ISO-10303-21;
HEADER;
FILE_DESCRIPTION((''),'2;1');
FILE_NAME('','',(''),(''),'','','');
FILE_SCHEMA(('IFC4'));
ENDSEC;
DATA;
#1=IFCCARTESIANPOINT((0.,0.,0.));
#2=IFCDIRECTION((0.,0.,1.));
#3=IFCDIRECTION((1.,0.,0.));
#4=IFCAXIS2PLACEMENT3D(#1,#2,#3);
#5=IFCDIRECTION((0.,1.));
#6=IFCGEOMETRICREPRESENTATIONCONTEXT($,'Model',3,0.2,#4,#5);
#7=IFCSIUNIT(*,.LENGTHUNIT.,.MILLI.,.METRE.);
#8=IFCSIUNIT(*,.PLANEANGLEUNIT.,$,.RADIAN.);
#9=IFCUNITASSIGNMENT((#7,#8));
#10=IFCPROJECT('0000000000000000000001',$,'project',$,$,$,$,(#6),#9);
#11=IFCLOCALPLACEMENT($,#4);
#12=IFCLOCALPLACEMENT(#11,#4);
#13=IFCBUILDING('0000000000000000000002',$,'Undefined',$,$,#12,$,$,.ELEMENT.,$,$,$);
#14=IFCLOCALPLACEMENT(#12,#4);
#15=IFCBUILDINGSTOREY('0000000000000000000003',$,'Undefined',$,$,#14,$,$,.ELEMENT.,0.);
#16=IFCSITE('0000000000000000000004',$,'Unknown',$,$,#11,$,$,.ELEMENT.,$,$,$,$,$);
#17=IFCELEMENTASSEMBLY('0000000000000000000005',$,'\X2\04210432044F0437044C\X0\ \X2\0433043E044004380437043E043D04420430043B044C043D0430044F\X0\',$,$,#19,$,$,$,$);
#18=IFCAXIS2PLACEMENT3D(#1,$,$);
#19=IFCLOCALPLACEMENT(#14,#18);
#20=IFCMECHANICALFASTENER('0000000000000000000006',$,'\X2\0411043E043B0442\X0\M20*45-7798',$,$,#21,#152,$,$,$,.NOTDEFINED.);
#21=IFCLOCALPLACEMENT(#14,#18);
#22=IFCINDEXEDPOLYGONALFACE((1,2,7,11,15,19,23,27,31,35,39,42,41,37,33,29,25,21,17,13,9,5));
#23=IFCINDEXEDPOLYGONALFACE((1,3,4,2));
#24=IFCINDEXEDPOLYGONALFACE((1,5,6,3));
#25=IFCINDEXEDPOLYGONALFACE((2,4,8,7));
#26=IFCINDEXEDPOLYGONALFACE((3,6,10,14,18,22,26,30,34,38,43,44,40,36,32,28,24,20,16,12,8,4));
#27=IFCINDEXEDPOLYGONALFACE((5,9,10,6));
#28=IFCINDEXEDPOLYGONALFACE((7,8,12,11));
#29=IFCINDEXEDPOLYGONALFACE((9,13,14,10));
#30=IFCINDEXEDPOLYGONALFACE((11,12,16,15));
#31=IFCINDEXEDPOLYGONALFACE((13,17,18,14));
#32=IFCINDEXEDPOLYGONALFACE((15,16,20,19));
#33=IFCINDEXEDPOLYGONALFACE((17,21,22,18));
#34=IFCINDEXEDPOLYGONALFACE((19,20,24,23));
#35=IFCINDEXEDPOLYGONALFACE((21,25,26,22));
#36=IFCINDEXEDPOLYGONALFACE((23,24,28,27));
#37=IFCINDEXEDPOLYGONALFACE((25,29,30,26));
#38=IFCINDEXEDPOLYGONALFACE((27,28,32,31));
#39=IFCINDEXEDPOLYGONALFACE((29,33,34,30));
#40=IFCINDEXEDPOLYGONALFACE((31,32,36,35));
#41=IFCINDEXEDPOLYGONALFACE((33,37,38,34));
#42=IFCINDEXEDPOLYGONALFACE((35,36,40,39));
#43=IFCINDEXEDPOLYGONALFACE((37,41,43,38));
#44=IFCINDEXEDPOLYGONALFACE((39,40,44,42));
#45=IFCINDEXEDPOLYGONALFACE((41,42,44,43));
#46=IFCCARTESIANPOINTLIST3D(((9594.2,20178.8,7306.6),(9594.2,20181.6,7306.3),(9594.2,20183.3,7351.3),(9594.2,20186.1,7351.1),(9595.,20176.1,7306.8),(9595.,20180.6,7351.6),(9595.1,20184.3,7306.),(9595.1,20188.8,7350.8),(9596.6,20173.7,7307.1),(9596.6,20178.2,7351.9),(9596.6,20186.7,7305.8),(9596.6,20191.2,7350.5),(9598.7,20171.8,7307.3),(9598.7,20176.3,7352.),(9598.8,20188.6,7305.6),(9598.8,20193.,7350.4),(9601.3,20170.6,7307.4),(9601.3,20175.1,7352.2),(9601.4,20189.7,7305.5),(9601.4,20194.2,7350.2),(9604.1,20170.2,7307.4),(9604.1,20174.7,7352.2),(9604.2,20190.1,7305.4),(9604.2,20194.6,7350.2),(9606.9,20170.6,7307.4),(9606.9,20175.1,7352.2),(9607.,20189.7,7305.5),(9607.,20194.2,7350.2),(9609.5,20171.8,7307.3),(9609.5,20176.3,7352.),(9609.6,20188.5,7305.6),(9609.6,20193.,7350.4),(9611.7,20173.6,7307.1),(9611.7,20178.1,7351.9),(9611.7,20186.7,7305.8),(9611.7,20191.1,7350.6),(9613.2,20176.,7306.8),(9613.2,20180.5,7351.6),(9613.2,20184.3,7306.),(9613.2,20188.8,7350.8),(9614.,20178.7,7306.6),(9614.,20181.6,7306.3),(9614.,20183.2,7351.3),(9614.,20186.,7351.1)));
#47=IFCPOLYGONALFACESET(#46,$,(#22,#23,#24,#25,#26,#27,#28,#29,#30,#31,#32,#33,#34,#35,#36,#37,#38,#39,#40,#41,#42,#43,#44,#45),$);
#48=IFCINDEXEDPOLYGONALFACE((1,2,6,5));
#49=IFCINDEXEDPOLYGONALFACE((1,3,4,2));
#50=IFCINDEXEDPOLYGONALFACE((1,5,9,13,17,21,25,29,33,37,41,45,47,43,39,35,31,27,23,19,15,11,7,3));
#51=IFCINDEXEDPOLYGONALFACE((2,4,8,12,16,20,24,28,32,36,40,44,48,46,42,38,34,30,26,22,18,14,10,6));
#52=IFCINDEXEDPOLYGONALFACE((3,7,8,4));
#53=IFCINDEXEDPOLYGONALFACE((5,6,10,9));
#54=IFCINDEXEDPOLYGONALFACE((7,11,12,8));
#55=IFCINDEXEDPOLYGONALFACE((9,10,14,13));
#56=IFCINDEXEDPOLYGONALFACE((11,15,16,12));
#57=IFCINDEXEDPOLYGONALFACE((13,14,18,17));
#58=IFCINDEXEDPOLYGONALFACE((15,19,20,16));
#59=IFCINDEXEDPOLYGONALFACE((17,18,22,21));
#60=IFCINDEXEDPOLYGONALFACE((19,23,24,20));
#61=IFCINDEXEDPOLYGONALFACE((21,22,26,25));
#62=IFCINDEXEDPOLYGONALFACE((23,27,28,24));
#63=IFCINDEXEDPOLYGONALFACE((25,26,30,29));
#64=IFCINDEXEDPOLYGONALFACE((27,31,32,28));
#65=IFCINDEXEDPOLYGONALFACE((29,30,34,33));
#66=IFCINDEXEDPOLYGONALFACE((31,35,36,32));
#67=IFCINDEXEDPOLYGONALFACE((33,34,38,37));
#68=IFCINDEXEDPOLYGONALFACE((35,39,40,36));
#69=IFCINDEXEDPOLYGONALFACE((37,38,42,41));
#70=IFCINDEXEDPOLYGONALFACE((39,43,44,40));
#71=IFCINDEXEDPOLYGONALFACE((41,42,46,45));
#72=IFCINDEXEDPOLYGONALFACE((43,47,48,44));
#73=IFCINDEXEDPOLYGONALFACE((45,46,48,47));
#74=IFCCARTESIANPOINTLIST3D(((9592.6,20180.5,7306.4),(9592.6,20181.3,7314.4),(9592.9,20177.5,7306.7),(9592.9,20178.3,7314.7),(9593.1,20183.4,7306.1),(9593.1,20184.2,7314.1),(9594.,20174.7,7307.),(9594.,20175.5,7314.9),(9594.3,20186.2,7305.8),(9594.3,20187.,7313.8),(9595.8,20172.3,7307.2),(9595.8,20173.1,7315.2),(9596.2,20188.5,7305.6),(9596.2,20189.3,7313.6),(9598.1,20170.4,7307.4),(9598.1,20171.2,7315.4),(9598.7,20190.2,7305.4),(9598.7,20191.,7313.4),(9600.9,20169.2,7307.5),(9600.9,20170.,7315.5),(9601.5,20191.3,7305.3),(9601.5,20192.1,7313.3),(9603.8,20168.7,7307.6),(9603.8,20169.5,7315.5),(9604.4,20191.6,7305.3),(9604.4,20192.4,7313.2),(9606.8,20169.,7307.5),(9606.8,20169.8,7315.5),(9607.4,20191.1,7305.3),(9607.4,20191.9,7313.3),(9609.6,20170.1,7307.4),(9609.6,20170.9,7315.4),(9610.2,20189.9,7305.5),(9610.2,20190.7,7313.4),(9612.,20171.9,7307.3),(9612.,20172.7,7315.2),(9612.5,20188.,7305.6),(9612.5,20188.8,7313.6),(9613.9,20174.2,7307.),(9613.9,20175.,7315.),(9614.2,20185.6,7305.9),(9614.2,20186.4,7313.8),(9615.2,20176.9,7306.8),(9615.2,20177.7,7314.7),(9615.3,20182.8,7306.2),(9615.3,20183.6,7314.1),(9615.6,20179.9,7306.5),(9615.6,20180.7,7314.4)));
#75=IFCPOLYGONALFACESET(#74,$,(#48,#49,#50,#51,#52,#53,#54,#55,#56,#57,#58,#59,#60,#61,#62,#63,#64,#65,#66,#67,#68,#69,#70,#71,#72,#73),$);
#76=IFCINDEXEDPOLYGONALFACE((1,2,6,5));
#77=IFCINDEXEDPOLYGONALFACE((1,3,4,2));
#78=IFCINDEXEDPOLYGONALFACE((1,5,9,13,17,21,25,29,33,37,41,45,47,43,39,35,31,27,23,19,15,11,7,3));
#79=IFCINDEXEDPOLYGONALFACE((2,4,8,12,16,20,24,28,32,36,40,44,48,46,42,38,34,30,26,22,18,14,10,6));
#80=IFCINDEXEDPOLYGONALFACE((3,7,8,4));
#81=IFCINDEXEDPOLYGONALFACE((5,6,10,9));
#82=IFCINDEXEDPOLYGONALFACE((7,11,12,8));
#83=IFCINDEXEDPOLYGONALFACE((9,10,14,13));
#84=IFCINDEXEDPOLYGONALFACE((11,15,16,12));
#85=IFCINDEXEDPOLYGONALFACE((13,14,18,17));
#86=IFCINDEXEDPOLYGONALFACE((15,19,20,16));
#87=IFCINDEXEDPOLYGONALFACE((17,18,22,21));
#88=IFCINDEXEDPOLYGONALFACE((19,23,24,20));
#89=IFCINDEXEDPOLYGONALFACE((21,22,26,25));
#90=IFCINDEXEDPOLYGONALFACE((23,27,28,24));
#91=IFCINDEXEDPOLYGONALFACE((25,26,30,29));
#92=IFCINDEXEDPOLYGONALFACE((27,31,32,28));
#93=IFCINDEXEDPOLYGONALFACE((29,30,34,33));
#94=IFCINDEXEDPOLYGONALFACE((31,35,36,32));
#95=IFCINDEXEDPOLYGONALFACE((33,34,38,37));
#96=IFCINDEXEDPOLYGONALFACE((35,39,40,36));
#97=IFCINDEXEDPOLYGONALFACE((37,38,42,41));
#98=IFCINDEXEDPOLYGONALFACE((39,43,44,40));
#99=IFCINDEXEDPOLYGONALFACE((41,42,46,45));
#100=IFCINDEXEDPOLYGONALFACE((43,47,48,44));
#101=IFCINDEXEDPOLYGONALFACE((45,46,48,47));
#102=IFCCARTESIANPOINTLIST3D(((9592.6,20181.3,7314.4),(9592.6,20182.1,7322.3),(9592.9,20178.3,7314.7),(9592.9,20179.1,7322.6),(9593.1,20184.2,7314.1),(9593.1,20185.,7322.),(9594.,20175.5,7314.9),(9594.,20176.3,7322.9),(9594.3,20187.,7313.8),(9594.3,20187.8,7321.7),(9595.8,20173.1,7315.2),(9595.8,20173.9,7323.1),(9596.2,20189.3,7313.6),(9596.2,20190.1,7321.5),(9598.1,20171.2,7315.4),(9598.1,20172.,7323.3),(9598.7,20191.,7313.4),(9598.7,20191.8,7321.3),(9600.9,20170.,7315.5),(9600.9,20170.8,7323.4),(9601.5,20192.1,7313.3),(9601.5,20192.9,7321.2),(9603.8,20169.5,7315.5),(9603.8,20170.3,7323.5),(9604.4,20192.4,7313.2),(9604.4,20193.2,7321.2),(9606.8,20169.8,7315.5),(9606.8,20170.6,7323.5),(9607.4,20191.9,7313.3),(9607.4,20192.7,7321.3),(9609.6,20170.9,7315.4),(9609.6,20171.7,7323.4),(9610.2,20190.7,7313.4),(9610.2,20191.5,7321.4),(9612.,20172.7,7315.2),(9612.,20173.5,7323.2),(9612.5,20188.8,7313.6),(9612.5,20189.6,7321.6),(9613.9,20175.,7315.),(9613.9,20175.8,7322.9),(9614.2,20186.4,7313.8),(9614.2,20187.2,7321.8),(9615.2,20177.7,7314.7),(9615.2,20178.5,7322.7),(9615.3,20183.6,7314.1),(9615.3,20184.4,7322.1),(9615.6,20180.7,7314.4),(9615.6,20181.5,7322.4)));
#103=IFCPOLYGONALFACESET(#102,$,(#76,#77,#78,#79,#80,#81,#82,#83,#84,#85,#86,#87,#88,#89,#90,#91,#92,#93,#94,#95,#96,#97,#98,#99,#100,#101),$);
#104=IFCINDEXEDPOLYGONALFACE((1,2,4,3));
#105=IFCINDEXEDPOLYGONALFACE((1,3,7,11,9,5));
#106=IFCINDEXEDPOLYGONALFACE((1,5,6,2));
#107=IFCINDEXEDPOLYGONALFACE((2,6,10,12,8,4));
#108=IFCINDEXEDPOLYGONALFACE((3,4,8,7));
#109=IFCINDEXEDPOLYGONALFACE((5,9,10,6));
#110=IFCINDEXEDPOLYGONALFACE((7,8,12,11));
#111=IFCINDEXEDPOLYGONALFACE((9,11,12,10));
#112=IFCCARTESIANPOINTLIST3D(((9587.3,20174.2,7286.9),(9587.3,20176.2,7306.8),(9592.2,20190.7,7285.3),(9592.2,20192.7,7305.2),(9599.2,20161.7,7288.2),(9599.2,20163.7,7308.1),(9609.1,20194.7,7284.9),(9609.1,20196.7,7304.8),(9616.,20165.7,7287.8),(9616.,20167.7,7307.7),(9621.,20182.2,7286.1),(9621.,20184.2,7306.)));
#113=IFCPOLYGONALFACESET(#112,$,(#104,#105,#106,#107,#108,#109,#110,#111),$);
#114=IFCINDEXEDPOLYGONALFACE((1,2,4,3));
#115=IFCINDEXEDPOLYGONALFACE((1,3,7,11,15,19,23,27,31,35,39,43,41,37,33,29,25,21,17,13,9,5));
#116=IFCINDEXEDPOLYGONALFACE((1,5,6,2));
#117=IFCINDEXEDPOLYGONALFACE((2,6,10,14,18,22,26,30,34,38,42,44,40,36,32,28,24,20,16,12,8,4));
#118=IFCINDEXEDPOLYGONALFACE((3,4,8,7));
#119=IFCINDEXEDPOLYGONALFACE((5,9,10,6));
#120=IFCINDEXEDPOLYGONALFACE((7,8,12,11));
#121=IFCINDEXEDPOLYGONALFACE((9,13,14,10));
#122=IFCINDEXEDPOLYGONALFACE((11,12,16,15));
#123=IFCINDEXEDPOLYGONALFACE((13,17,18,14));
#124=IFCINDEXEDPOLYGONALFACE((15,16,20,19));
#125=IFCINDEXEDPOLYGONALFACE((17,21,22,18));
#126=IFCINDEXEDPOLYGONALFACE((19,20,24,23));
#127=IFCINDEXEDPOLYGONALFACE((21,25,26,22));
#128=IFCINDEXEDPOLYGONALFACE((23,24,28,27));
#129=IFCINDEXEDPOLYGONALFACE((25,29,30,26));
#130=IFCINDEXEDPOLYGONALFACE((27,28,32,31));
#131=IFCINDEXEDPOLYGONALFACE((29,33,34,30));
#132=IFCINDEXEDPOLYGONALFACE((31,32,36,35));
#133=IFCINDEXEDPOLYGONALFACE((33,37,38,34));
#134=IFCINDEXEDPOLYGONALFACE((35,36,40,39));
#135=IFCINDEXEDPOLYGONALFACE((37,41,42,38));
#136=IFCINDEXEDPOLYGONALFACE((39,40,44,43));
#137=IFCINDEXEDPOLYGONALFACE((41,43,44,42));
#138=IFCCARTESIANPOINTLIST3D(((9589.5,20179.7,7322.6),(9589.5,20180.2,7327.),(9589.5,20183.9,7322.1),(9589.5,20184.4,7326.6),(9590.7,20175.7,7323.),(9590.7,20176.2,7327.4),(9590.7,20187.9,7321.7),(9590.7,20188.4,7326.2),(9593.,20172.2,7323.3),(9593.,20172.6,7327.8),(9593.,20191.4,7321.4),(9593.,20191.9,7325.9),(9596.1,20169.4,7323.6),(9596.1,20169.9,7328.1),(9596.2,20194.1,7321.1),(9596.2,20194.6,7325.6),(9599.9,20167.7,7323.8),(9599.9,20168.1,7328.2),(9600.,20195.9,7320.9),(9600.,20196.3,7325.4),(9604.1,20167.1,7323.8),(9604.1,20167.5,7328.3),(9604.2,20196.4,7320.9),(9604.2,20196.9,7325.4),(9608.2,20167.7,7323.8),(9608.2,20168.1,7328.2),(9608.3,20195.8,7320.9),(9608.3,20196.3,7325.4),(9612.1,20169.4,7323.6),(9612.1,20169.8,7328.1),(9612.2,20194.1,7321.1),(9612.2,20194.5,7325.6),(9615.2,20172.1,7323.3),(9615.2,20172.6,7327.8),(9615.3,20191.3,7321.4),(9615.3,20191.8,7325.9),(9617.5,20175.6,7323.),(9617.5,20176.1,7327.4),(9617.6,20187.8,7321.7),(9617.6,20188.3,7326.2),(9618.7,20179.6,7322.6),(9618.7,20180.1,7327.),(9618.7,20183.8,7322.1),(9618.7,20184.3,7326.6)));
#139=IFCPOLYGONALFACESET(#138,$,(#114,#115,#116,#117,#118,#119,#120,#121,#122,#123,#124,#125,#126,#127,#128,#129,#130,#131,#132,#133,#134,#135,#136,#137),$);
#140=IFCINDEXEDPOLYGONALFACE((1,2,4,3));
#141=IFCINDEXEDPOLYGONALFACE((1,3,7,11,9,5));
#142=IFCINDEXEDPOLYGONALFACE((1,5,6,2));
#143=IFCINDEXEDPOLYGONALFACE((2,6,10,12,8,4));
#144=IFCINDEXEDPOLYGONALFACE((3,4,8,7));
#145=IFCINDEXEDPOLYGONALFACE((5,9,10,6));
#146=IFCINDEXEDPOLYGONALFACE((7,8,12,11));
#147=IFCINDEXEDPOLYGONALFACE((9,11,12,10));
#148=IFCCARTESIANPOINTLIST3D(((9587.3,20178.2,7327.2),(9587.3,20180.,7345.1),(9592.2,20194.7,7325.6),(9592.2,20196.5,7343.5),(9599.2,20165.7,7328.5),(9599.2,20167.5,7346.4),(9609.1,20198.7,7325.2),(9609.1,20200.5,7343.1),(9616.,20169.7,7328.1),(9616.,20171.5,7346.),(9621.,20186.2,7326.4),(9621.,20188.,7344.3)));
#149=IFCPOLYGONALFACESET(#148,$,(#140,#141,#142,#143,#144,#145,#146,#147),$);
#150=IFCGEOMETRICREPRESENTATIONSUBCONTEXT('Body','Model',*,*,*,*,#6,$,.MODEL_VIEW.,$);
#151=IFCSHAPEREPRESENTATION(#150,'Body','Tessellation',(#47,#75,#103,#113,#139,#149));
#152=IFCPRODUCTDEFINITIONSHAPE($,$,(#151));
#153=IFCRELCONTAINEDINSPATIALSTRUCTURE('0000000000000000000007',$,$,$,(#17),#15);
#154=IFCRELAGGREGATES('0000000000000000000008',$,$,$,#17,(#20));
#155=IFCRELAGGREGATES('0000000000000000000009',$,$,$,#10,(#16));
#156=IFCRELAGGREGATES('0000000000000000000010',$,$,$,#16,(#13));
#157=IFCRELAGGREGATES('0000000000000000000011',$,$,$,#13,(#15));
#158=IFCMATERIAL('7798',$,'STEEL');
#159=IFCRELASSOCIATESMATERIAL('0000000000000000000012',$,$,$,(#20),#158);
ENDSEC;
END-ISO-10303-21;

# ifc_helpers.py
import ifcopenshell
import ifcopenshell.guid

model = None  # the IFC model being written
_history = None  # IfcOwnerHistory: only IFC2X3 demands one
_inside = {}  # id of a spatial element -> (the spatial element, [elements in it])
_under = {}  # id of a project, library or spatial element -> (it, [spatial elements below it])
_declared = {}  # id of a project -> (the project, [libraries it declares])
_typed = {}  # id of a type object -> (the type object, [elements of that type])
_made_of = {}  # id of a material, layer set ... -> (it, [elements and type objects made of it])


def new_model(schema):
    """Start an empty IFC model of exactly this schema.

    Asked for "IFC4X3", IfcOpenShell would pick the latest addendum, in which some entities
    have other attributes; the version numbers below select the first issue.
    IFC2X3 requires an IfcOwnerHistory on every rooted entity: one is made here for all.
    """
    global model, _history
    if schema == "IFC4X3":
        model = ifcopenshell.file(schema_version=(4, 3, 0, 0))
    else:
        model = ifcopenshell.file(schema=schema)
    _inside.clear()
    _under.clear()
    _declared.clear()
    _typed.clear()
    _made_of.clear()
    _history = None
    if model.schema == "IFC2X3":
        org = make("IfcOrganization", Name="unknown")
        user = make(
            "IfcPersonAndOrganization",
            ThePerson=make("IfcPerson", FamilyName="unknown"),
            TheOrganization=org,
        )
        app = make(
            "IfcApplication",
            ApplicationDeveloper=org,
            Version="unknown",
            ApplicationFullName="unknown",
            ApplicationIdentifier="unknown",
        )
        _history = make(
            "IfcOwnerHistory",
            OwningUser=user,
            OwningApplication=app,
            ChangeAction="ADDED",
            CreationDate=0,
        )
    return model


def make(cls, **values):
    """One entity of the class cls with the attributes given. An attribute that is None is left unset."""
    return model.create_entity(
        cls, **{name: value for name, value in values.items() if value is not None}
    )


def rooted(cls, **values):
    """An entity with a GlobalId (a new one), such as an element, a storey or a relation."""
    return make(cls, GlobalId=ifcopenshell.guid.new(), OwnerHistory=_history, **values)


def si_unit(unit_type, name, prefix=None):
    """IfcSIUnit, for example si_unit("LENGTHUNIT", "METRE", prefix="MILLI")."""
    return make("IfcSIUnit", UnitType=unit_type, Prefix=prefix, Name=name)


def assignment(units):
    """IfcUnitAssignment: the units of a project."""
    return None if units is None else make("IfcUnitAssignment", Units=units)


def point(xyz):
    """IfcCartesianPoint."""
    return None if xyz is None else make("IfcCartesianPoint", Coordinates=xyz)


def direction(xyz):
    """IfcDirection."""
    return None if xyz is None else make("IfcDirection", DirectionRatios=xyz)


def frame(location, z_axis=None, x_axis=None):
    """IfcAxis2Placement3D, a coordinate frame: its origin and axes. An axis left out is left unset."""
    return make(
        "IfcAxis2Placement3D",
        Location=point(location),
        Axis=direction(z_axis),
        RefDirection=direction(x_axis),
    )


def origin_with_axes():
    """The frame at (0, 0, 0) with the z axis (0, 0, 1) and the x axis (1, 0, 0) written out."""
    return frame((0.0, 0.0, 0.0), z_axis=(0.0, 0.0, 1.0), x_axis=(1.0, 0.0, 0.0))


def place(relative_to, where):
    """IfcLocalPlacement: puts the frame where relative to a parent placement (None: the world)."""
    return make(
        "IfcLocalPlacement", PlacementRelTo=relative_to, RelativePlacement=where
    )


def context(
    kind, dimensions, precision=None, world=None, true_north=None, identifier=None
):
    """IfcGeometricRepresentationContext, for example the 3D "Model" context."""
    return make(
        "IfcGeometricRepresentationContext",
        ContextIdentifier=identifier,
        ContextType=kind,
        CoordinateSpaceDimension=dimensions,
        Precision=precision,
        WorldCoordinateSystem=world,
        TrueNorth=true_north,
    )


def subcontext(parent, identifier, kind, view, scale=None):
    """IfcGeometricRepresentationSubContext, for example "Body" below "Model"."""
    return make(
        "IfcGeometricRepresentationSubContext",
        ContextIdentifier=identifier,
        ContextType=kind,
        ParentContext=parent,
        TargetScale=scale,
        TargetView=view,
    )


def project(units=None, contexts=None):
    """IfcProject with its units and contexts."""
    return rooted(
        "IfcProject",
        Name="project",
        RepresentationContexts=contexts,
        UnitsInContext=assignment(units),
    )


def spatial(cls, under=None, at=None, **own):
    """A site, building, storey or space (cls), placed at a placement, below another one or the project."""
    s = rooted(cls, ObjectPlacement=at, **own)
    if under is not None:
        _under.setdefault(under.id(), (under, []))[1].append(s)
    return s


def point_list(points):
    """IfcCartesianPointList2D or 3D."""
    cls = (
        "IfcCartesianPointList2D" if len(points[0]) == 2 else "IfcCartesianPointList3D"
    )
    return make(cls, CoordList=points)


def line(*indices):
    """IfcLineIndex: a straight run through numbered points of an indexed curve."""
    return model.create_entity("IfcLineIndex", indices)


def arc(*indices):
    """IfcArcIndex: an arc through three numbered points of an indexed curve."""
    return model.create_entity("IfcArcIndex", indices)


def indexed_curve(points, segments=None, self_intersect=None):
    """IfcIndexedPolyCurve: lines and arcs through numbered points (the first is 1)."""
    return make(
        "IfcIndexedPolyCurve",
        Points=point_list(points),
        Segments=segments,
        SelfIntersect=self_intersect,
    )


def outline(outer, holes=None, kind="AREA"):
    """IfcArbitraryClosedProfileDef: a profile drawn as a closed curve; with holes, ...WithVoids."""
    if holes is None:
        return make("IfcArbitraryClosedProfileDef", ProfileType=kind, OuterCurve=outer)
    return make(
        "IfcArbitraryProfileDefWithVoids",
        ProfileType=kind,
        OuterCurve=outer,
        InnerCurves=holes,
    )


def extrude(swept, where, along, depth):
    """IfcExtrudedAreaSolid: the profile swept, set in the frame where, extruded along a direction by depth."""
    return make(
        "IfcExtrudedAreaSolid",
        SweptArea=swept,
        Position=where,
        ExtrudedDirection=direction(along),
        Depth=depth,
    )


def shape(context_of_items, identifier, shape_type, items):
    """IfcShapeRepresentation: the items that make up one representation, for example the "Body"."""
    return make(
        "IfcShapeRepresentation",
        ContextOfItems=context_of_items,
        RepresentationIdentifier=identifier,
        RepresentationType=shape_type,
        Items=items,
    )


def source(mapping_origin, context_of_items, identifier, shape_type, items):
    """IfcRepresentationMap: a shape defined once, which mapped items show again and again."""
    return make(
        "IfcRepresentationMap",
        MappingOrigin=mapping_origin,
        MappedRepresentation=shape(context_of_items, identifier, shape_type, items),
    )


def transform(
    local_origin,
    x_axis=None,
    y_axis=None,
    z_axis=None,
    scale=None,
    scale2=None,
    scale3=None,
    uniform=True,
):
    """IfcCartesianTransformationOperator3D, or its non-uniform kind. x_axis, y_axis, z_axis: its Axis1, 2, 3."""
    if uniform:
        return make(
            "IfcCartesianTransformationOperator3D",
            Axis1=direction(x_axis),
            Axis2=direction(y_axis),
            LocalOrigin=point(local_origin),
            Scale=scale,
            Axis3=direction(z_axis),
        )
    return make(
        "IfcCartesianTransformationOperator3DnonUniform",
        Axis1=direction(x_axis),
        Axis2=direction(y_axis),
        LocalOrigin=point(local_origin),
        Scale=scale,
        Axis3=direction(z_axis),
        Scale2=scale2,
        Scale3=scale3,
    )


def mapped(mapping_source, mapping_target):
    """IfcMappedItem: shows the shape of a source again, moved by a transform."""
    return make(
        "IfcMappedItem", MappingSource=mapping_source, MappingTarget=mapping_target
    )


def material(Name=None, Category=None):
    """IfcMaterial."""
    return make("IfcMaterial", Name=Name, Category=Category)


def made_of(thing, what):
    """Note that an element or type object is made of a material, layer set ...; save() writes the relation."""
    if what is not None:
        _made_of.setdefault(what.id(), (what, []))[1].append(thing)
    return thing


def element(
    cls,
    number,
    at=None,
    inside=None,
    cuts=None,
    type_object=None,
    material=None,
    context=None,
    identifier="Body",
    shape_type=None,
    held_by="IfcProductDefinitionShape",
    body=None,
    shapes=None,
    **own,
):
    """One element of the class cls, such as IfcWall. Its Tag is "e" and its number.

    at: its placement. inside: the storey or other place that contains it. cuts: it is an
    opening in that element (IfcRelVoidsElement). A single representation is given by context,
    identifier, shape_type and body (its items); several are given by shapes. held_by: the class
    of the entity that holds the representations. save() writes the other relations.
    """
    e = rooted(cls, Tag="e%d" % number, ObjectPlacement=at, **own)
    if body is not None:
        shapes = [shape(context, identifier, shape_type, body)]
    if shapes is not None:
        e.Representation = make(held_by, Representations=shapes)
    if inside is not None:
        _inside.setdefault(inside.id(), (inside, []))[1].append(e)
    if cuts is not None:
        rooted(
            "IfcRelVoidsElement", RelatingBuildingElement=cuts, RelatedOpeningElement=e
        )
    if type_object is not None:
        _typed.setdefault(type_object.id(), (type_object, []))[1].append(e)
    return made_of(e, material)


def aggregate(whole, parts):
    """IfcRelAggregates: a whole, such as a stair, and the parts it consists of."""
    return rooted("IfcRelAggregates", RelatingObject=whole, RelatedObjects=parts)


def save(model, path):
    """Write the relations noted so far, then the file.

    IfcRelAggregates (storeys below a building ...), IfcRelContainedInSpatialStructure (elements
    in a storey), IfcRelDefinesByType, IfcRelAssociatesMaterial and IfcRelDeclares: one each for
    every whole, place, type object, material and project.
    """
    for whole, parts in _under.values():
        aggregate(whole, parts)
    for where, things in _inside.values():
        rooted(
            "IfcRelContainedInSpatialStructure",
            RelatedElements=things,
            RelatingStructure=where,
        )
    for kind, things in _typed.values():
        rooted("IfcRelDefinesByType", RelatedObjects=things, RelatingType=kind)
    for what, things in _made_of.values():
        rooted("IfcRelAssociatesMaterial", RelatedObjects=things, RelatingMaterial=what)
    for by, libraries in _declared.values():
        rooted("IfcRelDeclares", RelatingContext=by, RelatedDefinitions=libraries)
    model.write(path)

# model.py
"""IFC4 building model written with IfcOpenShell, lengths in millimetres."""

from ifc_helpers import new_model, si_unit, direction, frame, origin_with_axes, place, context, subcontext, project, spatial, line, arc, indexed_curve, outline, extrude, source, transform, mapped, material, element, aggregate, save


model = new_model("IFC4")

# Units and contexts
model_context = context("Model", 3, precision=0.2, world=origin_with_axes(), true_north=direction((0.0, 1.0)))
body_context = subcontext(model_context, "Body", "Model", "MODEL_VIEW")
ifc_project = project(units=[si_unit("LENGTHUNIT", "METRE", prefix="MILLI"), si_unit("PLANEANGLEUNIT", "RADIAN")], contexts=[model_context])

# Site, building, storey
site_placement = place(None, origin_with_axes())
site = spatial("IfcSite", under=ifc_project, at=site_placement, Name="Unknown", CompositionType="ELEMENT")
building_placement = place(site_placement, origin_with_axes())
building = spatial("IfcBuilding", under=site, at=building_placement, Name="Undefined", CompositionType="ELEMENT")
storey_placement = place(building_placement, origin_with_axes())
storey = spatial("IfcBuildingStorey", under=building, at=storey_placement, Name="Undefined", CompositionType="ELEMENT", Elevation=0.0)

# Element assembly
assembly_1_placement = place(storey_placement, frame((8658.2, 20461.5, 7290.4), z_axis=(-0.285231, -0.953702, 0.09537), x_axis=(0.958459, -0.283816, 0.028382)))
assembly_1 = element("IfcElementAssembly", 1, at=assembly_1_placement, inside=storey, Name="Связь горизонтальная")

# Shared definitions
ifc_material_1 = material(Name="7798", Category="STEEL")

# Mechanical fastener
shared_shape_1 = source(origin_with_axes(), body_context, "Body", "SweptSolid", [
    extrude(outline(indexed_curve([(10.0, 0.0), (0.0, 10.0), (-10.0, 0.0), (0.0, -10.0)], segments=[arc(1, 2, 3), arc(3, 4, 1)])), frame((0.0, 0.0, 12.0), z_axis=(0.0, 0.0, -1.0), x_axis=(0.0, 1.0, 0.0)), (0.0, 0.0, 1.0), 45.0),
    extrude(outline(indexed_curve([(0.0, 11.5), (8.1, 8.1), (11.5, 0.0), (8.1, -8.1), (0.0, -11.5), (-1.0, -11.5), (-11.5, 0.0), (-8.1, 8.1)], segments=[arc(1, 2, 3), arc(3, 4, 5), arc(5, 6, 7), arc(7, 8, 1)])), frame((0.0, 0.0, 12.0), z_axis=(0.0, 0.0, -1.0), x_axis=(0.0, 1.0, 0.0)), (0.0, 0.0, 1.0), 8.0),
    extrude(outline(indexed_curve([(0.0, 11.5), (8.1, 8.1), (11.5, 0.0), (8.1, -8.1), (0.0, -11.5), (-1.0, -11.5), (-11.5, 0.0), (-8.1, 8.1)], segments=[arc(1, 2, 3), arc(3, 4, 5), arc(5, 6, 7), arc(7, 8, 1)])), frame((0.0, 0.0, 4.0), z_axis=(0.0, 0.0, -1.0), x_axis=(0.0, 1.0, 0.0)), (0.0, 0.0, 1.0), 8.0),
    extrude(outline(indexed_curve([(17.3, 0.0), (8.7, 15.0), (-8.7, 15.0), (-17.3, 0.0), (-8.7, -15.0), (8.7, -15.0)], segments=[line(1, 2, 3, 4, 5, 6, 1)])), frame((0.0, 0.0, 32.0), z_axis=(0.0, 0.0, -1.0), x_axis=(0.0, 1.0, 0.0)), (0.0, 0.0, 1.0), 20.0),
    extrude(outline(indexed_curve([(14.8, 0.0), (0.0, 14.8), (-14.8, 0.0), (0.0, -14.8)], segments=[arc(1, 2, 3), arc(3, 4, 1)])), frame((0.0, 0.0, -4.0), z_axis=(0.0, 0.0, -1.0), x_axis=(0.0, 1.0, 0.0)), (0.0, 0.0, 1.0), 4.5),
    extrude(outline(indexed_curve([(17.3, 0.0), (8.7, 15.0), (-8.7, 15.0), (-17.3, 0.0), (-8.7, -15.0), (8.7, -15.0)], segments=[line(1, 2, 3, 4, 5, 6, 1)])), frame((0.0, 0.0, -8.5), z_axis=(0.0, 0.0, -1.0), x_axis=(0.0, 1.0, 0.0)), (0.0, 0.0, 1.0), 18.0),
])
mechanical_fastener_1_placement = place(assembly_1_placement, frame((987.0, 0.0, 0.0), z_axis=(0.0, -1.0, 0.0), x_axis=(-1.0, 0.0, 0.0)))
mechanical_fastener_1 = element("IfcMechanicalFastener", 2, at=mechanical_fastener_1_placement, material=ifc_material_1, Name="БолтM20*45-7798", PredefinedType="NOTDEFINED", context=body_context, shape_type="MappedRepresentation", body=[
    mapped(shared_shape_1, transform((0.0, 0.0, 0.0))),
])
aggregate(assembly_1, [mechanical_fastener_1])

save(model, "model.ifc")
